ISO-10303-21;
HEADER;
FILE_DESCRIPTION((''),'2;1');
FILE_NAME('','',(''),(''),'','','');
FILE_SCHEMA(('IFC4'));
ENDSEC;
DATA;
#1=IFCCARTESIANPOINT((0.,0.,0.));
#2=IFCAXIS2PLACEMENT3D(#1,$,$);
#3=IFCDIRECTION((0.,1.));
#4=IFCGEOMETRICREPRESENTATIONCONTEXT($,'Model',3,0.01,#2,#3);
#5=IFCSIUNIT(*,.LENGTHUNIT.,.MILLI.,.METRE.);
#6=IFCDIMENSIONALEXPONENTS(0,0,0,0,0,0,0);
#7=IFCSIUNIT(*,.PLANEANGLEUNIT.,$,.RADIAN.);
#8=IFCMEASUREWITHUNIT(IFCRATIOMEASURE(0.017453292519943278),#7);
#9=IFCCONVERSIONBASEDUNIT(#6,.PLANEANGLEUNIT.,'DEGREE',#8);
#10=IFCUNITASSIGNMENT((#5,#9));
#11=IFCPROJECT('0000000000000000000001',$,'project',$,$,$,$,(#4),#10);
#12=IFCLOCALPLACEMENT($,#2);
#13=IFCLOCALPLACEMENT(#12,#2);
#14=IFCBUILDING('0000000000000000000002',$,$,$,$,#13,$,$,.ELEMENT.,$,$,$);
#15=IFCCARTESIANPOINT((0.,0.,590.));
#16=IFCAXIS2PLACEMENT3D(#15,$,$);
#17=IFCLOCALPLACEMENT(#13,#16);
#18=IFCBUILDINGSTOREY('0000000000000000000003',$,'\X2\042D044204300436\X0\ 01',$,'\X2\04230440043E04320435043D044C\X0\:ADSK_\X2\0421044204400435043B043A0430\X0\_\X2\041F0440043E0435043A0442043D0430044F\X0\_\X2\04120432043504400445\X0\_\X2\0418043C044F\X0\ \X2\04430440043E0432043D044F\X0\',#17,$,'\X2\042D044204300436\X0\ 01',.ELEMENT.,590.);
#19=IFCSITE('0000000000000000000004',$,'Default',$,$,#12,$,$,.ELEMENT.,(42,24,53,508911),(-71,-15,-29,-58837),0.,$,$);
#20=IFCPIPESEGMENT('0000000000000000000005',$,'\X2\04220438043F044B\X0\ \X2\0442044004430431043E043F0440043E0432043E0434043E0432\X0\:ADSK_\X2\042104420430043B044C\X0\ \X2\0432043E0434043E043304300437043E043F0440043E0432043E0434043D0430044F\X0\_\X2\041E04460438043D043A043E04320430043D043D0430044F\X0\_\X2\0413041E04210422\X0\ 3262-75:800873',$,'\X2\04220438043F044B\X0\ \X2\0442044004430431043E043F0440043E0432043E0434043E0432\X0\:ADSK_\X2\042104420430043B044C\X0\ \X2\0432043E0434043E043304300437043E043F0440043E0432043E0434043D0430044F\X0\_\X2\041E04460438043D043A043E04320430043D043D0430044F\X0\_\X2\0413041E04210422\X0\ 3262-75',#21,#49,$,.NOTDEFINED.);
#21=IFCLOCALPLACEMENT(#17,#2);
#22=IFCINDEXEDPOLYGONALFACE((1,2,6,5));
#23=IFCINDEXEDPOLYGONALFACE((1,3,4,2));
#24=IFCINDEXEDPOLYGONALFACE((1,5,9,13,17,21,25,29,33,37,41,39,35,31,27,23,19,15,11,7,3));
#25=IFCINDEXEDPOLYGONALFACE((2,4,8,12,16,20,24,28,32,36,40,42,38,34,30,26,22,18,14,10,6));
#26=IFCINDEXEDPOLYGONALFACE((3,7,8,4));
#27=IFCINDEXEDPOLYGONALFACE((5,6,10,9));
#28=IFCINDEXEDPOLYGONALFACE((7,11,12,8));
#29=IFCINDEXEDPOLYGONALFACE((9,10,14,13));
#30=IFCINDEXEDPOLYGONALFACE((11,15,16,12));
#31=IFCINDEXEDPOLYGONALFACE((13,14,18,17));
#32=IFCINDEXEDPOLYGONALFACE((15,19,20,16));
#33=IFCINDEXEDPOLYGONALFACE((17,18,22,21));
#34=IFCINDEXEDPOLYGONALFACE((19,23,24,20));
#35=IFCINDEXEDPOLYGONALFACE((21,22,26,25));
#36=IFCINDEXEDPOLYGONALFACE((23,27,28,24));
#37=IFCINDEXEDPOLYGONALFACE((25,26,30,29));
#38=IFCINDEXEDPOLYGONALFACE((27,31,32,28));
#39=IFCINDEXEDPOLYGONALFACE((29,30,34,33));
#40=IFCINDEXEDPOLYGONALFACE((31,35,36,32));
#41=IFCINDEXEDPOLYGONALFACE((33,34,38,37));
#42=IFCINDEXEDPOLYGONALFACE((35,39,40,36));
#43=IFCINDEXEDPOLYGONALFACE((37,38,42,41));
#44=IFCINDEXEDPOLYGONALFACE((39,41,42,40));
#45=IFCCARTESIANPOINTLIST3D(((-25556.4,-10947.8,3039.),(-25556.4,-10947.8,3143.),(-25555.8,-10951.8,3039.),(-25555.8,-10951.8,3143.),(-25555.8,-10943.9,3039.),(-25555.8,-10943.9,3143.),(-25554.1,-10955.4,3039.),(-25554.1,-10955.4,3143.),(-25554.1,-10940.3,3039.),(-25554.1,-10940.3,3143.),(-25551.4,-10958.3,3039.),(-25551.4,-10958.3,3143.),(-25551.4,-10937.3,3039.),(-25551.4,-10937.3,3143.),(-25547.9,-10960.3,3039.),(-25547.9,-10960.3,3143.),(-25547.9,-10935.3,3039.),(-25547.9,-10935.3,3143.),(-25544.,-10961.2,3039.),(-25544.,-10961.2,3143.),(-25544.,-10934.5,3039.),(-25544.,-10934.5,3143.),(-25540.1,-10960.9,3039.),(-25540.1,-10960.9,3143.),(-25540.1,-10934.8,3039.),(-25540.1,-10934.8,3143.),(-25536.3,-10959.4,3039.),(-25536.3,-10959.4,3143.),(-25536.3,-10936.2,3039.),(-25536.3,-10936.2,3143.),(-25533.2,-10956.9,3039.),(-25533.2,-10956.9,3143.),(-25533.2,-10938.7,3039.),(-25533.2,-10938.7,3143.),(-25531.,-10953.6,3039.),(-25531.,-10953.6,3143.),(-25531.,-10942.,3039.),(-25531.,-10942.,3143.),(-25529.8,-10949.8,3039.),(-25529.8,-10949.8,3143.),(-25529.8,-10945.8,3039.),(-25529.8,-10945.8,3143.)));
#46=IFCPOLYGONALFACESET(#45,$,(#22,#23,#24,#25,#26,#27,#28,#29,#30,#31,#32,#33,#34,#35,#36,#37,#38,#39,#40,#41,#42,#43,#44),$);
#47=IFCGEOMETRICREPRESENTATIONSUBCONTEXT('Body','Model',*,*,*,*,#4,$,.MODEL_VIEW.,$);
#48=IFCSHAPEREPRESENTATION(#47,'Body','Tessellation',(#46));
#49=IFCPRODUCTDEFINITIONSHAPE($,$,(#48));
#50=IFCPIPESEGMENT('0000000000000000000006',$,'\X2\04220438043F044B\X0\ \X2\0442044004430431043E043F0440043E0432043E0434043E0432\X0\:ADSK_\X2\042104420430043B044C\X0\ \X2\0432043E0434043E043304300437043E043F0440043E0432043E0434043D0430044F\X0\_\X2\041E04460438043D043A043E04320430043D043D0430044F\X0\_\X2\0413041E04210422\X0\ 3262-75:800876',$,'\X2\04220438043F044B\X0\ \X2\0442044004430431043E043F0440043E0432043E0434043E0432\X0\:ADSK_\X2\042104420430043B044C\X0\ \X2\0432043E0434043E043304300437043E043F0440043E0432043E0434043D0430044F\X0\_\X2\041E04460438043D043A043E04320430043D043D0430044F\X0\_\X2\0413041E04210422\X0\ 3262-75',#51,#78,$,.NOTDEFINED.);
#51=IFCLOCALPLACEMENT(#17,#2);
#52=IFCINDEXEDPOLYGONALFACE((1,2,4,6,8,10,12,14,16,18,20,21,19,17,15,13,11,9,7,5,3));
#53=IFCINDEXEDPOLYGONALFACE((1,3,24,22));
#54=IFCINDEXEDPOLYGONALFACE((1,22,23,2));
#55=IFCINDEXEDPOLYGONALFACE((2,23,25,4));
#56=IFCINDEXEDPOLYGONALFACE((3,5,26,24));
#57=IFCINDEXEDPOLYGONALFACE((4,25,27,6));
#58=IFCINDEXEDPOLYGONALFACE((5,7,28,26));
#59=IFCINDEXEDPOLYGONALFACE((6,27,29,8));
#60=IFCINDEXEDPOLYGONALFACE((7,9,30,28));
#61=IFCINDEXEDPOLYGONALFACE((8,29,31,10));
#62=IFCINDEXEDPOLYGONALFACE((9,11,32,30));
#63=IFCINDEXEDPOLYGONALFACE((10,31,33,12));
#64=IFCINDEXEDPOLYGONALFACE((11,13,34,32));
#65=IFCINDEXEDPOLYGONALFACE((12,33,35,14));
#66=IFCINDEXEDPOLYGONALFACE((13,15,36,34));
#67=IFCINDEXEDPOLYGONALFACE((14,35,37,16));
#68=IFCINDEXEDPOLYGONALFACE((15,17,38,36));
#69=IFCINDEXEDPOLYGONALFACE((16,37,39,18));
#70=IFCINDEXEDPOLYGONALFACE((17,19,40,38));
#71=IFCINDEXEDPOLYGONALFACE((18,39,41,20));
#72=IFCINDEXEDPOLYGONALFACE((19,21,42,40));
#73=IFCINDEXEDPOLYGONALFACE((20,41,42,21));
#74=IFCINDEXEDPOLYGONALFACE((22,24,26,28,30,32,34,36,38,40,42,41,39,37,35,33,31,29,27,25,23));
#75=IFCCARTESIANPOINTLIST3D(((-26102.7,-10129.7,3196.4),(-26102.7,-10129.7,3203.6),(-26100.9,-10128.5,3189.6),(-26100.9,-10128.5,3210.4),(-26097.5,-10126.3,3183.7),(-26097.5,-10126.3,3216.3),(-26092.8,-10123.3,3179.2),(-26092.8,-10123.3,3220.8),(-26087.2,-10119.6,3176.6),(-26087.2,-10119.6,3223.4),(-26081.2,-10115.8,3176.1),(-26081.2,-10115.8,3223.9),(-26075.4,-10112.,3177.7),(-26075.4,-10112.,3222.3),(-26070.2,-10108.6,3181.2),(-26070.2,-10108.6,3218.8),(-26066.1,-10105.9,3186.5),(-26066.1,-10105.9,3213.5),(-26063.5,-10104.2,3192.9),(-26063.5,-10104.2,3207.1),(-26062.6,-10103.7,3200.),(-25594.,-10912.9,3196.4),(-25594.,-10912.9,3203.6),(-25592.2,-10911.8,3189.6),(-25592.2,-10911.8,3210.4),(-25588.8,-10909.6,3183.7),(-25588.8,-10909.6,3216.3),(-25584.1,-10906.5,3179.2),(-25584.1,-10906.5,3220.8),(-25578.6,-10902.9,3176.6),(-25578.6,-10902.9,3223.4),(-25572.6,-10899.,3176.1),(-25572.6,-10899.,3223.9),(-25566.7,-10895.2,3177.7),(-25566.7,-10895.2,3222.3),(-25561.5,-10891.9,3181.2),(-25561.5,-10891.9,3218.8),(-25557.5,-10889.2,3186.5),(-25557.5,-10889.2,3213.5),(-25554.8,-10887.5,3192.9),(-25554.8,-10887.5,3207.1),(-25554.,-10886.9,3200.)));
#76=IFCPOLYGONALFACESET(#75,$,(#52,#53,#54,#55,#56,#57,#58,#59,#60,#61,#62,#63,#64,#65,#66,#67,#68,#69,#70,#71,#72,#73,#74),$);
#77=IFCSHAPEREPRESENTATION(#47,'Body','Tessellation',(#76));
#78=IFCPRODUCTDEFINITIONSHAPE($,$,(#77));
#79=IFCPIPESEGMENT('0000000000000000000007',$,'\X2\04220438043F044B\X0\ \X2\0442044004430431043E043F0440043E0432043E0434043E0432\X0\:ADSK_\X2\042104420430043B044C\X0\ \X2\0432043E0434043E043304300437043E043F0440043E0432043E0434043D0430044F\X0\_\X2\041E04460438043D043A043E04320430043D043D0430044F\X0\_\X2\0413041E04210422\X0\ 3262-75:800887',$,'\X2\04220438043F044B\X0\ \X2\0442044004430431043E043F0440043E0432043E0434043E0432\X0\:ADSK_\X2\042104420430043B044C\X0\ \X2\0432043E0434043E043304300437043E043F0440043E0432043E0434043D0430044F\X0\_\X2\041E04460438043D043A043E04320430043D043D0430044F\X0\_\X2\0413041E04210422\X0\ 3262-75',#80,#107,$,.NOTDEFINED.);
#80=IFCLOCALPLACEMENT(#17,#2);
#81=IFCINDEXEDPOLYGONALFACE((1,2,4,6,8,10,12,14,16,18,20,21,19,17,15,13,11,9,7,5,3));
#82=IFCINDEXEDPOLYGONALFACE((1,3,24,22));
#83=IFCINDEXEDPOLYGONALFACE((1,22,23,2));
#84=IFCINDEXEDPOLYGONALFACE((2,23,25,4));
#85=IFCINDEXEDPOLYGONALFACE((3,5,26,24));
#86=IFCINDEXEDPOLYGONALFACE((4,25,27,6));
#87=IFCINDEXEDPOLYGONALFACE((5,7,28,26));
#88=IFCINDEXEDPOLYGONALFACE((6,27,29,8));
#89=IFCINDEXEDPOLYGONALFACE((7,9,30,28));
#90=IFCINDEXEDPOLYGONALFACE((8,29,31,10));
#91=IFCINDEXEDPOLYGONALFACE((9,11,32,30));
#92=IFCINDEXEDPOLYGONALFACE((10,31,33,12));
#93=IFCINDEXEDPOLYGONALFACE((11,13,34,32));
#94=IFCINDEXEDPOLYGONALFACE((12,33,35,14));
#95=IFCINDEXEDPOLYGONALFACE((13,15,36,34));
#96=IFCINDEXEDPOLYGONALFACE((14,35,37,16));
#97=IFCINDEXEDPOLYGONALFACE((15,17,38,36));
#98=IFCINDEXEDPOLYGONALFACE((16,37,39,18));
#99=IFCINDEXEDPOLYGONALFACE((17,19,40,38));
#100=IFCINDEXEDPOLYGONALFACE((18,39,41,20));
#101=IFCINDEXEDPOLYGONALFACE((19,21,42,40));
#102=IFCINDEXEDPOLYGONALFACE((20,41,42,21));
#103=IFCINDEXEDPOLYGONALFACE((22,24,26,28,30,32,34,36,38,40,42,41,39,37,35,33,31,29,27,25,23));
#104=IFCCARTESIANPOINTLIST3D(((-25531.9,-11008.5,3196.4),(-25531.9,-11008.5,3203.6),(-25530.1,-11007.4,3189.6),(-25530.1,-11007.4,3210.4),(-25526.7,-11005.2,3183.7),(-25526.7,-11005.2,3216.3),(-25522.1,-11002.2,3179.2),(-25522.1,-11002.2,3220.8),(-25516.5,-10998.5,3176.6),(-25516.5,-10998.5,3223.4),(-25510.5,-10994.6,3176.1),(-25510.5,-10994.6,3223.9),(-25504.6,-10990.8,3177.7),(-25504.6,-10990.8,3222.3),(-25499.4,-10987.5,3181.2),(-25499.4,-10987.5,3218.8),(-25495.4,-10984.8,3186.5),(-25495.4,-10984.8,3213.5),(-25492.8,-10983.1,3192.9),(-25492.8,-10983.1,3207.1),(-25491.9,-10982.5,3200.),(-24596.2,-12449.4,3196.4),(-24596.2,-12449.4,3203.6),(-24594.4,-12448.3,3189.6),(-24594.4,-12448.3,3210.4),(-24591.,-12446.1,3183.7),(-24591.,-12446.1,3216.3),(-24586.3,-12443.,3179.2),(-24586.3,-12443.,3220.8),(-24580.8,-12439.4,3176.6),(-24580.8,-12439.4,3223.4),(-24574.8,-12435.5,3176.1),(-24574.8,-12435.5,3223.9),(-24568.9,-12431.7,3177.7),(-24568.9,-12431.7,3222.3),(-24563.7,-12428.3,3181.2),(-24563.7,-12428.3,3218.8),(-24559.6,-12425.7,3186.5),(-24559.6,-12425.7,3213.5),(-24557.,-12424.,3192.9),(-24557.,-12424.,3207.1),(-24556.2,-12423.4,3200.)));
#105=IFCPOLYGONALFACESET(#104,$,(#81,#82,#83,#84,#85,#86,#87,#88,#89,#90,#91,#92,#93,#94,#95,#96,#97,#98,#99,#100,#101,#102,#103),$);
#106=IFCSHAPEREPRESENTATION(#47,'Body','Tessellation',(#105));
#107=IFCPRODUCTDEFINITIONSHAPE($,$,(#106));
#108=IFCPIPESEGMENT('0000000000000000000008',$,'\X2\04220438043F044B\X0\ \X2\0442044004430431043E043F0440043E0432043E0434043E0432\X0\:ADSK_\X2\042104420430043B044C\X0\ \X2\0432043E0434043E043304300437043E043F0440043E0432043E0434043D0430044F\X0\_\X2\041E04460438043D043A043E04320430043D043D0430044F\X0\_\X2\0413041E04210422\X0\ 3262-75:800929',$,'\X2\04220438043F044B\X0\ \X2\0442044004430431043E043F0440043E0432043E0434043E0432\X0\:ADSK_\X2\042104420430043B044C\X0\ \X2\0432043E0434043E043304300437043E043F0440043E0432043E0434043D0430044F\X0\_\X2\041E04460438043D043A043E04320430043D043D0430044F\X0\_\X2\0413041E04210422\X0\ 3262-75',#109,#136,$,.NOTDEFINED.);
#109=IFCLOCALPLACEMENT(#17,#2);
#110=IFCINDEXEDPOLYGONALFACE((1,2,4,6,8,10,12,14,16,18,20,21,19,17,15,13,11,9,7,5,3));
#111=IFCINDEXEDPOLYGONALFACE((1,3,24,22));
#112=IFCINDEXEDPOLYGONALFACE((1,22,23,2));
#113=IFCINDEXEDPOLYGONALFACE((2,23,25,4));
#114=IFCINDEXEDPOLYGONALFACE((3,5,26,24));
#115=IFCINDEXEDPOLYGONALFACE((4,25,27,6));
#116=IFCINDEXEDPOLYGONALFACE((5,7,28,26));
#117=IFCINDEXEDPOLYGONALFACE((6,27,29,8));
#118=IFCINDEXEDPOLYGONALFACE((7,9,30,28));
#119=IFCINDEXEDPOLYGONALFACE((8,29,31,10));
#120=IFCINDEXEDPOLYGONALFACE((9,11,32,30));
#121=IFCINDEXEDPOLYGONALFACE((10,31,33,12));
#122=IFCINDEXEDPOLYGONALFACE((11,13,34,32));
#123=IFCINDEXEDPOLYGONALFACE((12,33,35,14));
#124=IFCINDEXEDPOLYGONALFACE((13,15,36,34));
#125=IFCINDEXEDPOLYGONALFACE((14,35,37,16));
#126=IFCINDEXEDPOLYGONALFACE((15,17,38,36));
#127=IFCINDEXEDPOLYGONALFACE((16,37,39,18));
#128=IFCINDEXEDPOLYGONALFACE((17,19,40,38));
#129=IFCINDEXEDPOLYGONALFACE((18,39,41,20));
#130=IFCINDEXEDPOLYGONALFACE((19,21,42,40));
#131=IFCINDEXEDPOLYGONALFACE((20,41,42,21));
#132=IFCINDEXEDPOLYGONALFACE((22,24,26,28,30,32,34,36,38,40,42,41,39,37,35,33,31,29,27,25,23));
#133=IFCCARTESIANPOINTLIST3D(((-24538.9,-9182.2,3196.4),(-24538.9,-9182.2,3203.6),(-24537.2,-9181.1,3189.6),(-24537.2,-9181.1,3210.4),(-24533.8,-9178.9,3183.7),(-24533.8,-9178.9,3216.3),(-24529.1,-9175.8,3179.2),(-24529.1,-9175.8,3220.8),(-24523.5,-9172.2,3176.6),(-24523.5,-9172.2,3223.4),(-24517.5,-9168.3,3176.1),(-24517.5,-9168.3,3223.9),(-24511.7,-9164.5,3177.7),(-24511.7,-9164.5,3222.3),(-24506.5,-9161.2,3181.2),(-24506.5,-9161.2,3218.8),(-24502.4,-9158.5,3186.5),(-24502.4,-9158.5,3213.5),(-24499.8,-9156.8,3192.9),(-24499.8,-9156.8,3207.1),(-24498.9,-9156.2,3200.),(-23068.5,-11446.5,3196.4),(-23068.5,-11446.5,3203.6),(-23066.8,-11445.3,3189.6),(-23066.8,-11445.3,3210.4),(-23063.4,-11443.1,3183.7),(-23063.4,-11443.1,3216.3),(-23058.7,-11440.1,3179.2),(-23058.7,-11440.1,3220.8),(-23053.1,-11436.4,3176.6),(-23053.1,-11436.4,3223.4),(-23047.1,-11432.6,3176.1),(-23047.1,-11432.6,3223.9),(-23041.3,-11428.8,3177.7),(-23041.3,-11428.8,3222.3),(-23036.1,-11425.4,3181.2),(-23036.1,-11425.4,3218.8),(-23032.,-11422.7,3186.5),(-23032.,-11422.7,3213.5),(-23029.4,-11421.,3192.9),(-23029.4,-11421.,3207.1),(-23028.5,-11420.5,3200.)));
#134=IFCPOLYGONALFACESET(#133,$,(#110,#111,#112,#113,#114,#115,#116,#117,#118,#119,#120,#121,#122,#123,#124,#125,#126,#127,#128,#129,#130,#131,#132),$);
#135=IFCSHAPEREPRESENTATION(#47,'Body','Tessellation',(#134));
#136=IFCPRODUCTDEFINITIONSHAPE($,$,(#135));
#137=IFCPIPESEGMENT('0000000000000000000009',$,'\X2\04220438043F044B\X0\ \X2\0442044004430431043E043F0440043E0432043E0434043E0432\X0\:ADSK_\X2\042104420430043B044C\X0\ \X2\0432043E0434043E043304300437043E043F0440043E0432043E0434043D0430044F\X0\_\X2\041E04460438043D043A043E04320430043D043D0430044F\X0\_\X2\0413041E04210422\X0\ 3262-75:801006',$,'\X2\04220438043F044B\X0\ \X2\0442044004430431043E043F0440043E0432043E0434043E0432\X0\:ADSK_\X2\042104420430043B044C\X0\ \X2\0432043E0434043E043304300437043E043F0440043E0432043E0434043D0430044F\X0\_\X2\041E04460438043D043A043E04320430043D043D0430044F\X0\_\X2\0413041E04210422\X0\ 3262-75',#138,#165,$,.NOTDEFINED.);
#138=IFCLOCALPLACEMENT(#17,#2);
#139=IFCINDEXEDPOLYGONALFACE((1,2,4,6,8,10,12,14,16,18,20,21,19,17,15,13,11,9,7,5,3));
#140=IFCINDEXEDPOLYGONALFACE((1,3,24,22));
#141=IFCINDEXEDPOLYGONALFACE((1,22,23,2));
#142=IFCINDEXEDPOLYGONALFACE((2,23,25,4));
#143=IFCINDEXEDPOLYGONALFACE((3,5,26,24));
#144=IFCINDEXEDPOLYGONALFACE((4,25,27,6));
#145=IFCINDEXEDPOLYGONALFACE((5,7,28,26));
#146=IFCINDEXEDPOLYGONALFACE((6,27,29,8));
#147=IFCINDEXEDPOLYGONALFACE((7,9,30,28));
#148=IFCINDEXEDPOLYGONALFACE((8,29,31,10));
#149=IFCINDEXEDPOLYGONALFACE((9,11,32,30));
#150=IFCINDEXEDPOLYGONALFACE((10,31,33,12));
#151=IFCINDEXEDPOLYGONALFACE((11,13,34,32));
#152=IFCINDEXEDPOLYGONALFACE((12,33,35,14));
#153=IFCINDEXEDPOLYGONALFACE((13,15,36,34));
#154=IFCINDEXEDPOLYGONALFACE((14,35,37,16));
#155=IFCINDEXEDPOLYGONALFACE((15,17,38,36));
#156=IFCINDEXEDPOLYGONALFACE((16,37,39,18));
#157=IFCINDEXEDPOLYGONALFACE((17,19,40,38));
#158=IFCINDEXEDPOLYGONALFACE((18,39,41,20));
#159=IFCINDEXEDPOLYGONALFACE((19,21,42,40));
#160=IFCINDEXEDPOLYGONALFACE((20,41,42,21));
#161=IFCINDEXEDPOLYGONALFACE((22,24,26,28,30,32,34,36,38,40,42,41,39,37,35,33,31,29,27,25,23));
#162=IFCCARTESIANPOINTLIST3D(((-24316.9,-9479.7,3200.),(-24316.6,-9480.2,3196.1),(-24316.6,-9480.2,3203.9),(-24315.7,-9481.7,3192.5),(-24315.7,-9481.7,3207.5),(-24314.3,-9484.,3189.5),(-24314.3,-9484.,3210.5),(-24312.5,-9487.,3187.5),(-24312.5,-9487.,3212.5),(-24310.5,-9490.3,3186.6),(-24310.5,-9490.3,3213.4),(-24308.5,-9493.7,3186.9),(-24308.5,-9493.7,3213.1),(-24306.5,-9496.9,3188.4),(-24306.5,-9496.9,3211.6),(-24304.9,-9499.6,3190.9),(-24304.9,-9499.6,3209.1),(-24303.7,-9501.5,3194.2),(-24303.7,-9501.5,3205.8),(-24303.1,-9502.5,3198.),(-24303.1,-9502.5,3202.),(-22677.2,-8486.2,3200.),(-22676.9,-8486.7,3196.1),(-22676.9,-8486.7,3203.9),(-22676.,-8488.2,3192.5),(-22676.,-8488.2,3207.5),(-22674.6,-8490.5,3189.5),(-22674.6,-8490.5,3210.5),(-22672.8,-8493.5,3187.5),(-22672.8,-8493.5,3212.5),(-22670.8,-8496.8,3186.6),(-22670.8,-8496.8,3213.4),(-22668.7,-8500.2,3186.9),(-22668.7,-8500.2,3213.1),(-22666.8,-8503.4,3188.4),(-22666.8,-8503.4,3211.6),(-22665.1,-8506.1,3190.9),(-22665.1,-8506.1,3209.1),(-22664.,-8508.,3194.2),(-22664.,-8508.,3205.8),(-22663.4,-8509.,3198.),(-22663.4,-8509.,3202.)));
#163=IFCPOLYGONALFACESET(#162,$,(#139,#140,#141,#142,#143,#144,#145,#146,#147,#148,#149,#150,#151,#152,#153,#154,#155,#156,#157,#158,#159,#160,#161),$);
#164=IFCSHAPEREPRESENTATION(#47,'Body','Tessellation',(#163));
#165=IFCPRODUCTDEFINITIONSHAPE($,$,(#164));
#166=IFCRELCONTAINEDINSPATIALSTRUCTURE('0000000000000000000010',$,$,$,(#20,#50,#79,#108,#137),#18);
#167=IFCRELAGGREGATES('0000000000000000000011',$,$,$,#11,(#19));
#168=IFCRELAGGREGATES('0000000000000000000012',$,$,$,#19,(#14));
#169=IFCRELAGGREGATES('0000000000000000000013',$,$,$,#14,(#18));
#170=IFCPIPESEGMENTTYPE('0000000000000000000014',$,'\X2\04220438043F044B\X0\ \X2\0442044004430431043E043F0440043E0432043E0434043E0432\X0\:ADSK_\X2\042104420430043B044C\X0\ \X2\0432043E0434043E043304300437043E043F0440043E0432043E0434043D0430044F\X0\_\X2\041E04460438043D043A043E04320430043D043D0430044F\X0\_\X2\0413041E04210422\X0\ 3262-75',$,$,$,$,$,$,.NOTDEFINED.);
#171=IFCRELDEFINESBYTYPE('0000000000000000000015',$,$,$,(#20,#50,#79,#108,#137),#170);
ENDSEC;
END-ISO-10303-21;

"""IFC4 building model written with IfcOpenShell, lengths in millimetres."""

from ifc_helpers import new_model, entity, si_unit, converted_unit, direction, frame, origin, origin_2d_with_axis, place, context, subcontext, project, spatial, circle, extrude, type_object, element, save


model = new_model("IFC4")

# Units and contexts
model_context = context("Model", 3, precision=0.01, world=origin(), true_north=direction((0.0, 1.0)))
body_context = subcontext(model_context, "Body", "Model", "MODEL_VIEW")
ifc_project = project(units=[si_unit("LENGTHUNIT", "METRE", prefix="MILLI"), converted_unit("PLANEANGLEUNIT", "DEGREE", entity("IfcRatioMeasure", 0.017453292519943278), si_unit("PLANEANGLEUNIT", "RADIAN"), dimensions=[0, 0, 0, 0, 0, 0, 0])], contexts=[model_context])

# Site, building, storey
site_placement = place(None, origin())
site = spatial("IfcSite", under=ifc_project, at=site_placement, Name="Default", CompositionType="ELEMENT", RefLatitude=(42, 24, 53, 508911), RefLongitude=(-71, -15, -29, -58837), RefElevation=0.0)
building_placement = place(site_placement, origin())
building = spatial("IfcBuilding", under=site, at=building_placement, CompositionType="ELEMENT")
storey_placement = place(building_placement, frame((0.0, 0.0, 590.0)))
storey = spatial("IfcBuildingStorey", under=building, at=storey_placement, Name="Этаж 01", ObjectType="Уровень:ADSK_Стрелка_Проектная_Вверх_Имя уровня", LongName="Этаж 01", CompositionType="ELEMENT", Elevation=590.0)

# Pipe segments
pipe_segment_type = type_object("IfcPipeSegmentType", Name="Типы трубопроводов:ADSK_Сталь водогазопроводная_Оцинкованная_ГОСТ 3262-75", PredefinedType="NOTDEFINED")
pipe_segment_1_placement = place(storey_placement, frame((-25558.0, -10962.8, 3143.0)))
element("IfcPipeSegment", 1, at=pipe_segment_1_placement, inside=storey, type_object=pipe_segment_type, Name="Типы трубопроводов:ADSK_Сталь водогазопроводная_Оцинкованная_ГОСТ 3262-75:800873", ObjectType="Типы трубопроводов:ADSK_Сталь водогазопроводная_Оцинкованная_ГОСТ 3262-75", PredefinedType="NOTDEFINED", context=body_context, shape_type="SweptSolid", body=[
    extrude(circle(Radius=13.4, at=origin_2d_with_axis()), frame((15.0, 15.0, -104.0), z_axis=(0.0, 0.0, 1.0), x_axis=(-1.0, 0.0, 0.0)), (0.0, 0.0, 1.0), 104.0),
])
pipe_segment_2_placement = place(storey_placement, frame((-26104.5, -10914.7, 3174.4)))
element("IfcPipeSegment", 2, at=pipe_segment_2_placement, inside=storey, type_object=pipe_segment_type, Name="Типы трубопроводов:ADSK_Сталь водогазопроводная_Оцинкованная_ГОСТ 3262-75:800876", ObjectType="Типы трубопроводов:ADSK_Сталь водогазопроводная_Оцинкованная_ГОСТ 3262-75", PredefinedType="NOTDEFINED", context=body_context, shape_type="SweptSolid", body=[
    extrude(circle(Radius=24.0, at=origin_2d_with_axis()), frame((21.7, 797.9, 25.6), z_axis=(0.544639, -0.838671, 0.0), x_axis=(0.838671, 0.544639, 0.0)), (0.0, 0.0, 1.0), 934.0),
])
pipe_segment_3_placement = place(storey_placement, frame((-25533.7, -12451.2, 3174.4)))
element("IfcPipeSegment", 3, at=pipe_segment_3_placement, inside=storey, type_object=pipe_segment_type, Name="Типы трубопроводов:ADSK_Сталь водогазопроводная_Оцинкованная_ГОСТ 3262-75:800887", ObjectType="Типы трубопроводов:ADSK_Сталь водогазопроводная_Оцинкованная_ГОСТ 3262-75", PredefinedType="NOTDEFINED", context=body_context, shape_type="SweptSolid", body=[
    extrude(circle(Radius=24.0, at=origin_2d_with_axis()), frame((21.7, 1455.5, 25.6), z_axis=(0.544639, -0.838671, 0.0), x_axis=(0.838671, 0.544639, 0.0)), (0.0, 0.0, 1.0), 1718.0),
])
pipe_segment_4_placement = place(storey_placement, frame((-24540.8, -11448.2, 3174.4)))
element("IfcPipeSegment", 4, at=pipe_segment_4_placement, inside=storey, type_object=pipe_segment_type, Name="Типы трубопроводов:ADSK_Сталь водогазопроводная_Оцинкованная_ГОСТ 3262-75:800929", ObjectType="Типы трубопроводов:ADSK_Сталь водогазопроводная_Оцинкованная_ГОСТ 3262-75", PredefinedType="NOTDEFINED", context=body_context, shape_type="SweptSolid", body=[
    extrude(circle(Radius=24.0, at=origin_2d_with_axis()), frame((21.7, 2278.9, 25.6), z_axis=(0.544639, -0.838671, 0.0), x_axis=(0.838671, 0.544639, 0.0)), (0.0, 0.0, 1.0), 2699.8),
])
pipe_segment_5_placement = place(storey_placement, frame((-24318.5, -9504.2, 3185.0)))
element("IfcPipeSegment", 5, at=pipe_segment_5_placement, inside=storey, type_object=pipe_segment_type, Name="Типы трубопроводов:ADSK_Сталь водогазопроводная_Оцинкованная_ГОСТ 3262-75:801006", ObjectType="Типы трубопроводов:ADSK_Сталь водогазопроводная_Оцинкованная_ГОСТ 3262-75", PredefinedType="NOTDEFINED", context=body_context, shape_type="SweptSolid", body=[
    extrude(circle(Radius=13.4, at=origin_2d_with_axis()), frame((8.5, 13.1, 15.0), z_axis=(0.855267, 0.518188, 0.0), x_axis=(-0.518188, 0.855267, 0.0)), (0.0, 0.0, 1.0), 1917.2),
])

save(model, "model.ifc")
